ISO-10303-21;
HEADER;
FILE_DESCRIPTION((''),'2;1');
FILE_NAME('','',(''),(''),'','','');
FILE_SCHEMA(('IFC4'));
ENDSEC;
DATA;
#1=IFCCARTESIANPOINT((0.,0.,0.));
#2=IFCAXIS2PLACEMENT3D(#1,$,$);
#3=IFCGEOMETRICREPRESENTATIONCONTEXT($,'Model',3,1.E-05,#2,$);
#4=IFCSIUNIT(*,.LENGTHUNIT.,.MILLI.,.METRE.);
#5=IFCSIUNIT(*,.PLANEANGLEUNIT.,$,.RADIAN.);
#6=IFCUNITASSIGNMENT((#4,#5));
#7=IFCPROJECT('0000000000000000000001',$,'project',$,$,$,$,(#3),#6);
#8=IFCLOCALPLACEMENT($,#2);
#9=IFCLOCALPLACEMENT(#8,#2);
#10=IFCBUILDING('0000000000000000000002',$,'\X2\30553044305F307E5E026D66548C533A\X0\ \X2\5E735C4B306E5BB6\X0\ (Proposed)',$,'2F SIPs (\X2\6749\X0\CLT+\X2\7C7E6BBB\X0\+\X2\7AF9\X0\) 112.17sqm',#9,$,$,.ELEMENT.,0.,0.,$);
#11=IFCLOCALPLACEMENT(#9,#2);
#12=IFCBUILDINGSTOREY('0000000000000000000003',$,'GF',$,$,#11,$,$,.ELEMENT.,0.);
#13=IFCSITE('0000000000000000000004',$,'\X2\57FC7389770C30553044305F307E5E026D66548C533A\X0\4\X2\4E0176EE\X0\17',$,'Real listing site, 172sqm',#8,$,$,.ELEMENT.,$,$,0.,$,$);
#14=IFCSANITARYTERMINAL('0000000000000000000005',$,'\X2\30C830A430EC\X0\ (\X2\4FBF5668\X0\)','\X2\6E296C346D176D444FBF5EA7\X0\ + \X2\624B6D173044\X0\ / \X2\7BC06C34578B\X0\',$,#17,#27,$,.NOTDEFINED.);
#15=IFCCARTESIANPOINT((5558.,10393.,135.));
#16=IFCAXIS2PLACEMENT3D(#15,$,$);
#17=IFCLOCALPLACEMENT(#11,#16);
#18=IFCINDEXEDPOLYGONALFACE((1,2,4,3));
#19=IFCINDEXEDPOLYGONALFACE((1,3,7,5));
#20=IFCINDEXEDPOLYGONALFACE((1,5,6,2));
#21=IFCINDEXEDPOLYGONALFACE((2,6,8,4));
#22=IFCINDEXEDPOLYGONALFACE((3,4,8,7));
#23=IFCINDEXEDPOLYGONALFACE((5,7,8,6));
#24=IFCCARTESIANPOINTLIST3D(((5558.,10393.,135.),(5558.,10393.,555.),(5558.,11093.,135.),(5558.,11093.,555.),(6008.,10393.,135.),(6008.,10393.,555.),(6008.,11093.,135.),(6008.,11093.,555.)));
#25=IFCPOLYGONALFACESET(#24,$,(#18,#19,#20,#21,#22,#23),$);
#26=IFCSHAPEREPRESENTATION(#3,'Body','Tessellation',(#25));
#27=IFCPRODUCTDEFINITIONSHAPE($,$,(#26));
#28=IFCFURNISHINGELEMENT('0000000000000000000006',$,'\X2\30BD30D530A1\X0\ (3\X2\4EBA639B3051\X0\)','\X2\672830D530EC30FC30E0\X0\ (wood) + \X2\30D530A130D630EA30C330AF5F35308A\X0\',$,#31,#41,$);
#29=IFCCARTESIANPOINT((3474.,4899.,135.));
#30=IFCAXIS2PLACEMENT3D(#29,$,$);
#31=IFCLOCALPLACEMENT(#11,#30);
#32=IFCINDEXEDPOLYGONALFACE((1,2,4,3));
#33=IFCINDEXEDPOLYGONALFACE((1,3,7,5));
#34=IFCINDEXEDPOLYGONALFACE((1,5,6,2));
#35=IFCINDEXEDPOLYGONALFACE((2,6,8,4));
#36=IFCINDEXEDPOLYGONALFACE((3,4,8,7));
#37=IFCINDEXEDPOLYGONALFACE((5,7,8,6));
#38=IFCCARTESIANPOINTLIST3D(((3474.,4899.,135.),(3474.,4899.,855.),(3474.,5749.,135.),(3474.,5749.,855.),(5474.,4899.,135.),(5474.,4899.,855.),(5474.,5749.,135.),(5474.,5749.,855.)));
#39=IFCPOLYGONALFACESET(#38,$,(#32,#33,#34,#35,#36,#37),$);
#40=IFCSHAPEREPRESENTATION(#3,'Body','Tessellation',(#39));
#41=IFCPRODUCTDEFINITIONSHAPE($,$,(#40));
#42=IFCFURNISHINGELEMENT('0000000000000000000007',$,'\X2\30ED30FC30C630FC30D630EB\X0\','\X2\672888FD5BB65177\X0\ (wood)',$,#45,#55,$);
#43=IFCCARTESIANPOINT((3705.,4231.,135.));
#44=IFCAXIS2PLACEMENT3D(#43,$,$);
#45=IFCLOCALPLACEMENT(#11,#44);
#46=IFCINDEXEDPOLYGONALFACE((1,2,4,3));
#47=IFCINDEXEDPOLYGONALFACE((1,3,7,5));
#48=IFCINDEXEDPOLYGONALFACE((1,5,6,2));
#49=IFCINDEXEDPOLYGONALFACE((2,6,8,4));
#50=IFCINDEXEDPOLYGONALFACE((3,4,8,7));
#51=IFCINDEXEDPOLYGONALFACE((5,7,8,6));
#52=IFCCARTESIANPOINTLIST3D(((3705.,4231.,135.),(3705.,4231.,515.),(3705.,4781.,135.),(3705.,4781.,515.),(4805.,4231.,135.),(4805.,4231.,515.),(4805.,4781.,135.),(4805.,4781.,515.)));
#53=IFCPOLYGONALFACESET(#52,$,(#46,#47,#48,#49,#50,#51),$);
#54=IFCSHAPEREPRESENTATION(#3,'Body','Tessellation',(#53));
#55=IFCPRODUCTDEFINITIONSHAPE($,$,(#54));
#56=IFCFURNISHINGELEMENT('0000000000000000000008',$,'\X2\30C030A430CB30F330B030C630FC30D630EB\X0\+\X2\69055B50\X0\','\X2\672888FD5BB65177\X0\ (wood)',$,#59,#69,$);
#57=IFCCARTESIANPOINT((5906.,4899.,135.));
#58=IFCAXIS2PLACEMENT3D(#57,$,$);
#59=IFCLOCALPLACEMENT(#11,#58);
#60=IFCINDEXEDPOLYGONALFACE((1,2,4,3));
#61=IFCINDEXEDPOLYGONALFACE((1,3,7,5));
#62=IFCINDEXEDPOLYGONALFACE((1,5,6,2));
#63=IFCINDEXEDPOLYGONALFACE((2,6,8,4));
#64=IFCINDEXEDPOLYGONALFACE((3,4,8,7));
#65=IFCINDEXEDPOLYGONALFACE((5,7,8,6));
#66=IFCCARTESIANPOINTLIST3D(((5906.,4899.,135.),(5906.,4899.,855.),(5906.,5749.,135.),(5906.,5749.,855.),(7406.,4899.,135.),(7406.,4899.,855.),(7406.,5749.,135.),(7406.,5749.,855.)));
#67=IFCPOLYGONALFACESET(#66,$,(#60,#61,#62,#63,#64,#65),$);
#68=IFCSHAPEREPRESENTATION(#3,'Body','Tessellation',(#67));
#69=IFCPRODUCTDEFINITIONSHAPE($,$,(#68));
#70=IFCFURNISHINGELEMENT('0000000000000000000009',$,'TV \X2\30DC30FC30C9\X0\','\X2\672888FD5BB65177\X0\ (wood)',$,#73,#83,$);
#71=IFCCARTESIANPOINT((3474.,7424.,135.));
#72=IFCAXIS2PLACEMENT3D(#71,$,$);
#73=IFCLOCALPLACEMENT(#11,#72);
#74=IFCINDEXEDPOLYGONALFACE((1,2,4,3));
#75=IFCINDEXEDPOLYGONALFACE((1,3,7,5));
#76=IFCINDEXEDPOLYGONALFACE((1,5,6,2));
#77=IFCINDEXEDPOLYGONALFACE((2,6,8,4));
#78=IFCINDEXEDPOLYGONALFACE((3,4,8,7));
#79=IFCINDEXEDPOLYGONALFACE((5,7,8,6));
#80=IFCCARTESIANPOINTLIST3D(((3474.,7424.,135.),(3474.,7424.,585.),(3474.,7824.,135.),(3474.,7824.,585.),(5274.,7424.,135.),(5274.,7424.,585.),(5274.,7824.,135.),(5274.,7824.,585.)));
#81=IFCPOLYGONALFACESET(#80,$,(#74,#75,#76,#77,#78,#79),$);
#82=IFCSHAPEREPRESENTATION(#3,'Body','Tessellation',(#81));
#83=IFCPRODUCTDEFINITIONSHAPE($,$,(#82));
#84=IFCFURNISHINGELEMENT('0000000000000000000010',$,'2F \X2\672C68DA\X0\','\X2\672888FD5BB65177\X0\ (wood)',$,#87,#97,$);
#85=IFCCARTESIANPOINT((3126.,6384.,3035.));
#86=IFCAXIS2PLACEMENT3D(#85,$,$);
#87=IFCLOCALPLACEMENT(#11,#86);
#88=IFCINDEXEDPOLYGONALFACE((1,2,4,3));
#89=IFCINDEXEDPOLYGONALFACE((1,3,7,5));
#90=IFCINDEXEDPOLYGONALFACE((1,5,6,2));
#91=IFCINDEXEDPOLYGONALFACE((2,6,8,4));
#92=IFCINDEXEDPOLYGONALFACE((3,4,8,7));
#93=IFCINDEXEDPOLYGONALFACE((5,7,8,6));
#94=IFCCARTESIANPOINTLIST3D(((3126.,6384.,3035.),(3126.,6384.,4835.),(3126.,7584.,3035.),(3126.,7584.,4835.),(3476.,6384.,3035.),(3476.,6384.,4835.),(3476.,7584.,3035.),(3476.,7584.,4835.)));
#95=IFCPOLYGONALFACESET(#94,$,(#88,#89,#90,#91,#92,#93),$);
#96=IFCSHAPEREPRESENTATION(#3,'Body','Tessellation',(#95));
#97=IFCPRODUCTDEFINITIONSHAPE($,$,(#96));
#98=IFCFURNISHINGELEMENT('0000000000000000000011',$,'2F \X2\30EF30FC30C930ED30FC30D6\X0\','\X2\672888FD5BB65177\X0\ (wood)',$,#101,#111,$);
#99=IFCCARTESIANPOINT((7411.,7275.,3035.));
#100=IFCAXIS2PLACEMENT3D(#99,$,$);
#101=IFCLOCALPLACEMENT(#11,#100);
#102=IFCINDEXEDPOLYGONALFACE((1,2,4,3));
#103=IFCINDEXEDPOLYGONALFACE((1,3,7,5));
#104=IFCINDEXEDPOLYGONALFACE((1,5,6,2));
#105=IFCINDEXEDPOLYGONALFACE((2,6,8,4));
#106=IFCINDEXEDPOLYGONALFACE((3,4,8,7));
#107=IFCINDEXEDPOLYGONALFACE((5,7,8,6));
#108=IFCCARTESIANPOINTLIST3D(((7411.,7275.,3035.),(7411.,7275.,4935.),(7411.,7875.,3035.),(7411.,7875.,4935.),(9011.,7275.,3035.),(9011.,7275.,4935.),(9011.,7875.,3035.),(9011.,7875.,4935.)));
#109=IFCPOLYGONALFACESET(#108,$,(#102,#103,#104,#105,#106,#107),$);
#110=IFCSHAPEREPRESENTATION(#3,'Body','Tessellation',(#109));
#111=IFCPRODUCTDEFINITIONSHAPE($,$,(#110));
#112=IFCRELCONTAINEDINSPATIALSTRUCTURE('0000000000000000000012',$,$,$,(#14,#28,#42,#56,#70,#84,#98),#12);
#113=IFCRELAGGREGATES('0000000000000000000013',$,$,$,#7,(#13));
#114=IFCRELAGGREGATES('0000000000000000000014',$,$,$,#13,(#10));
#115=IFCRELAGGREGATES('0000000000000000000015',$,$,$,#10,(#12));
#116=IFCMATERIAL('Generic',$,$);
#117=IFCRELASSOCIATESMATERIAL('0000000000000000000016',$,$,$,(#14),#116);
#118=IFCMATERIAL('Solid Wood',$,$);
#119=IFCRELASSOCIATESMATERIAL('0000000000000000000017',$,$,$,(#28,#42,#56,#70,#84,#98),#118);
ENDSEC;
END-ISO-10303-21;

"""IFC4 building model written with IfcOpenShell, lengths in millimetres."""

from ifc_helpers import new_model, si_unit, frame, frame_2d, origin, place, context, project, spatial, rectangle, extrude, material, element, save


model = new_model("IFC4")

# Units and contexts
model_context = context("Model", 3, precision=1e-05, world=origin())
ifc_project = project(units=[si_unit("LENGTHUNIT", "METRE", prefix="MILLI"), si_unit("PLANEANGLEUNIT", "RADIAN")], contexts=[model_context])

# Site, building, storey
site_placement = place(None, origin())
site = spatial("IfcSite", under=ifc_project, at=site_placement, Name="埼玉県さいたま市浦和区4丁目17", ObjectType="Real listing site, 172sqm", CompositionType="ELEMENT", RefElevation=0.0)
building_placement = place(site_placement, origin())
building = spatial("IfcBuilding", under=site, at=building_placement, Name="さいたま市浦和区 平屋の家 (Proposed)", ObjectType="2F SIPs (杉CLT+籾殻+竹) 112.17sqm", CompositionType="ELEMENT", ElevationOfRefHeight=0.0, ElevationOfTerrain=0.0)
storey_placement = place(building_placement, origin())
storey = spatial("IfcBuildingStorey", under=building, at=storey_placement, Name="GF", CompositionType="ELEMENT", Elevation=0.0)

# Shared definitions
ifc_material_1 = material(Name="Generic")

# Shared definitions
ifc_material_2 = material(Name="Solid Wood")

# Sanitary terminal
sanitary_terminal_1_placement = place(storey_placement, frame((5558.0, 10393.0, 135.0)))
element("IfcSanitaryTerminal", 1, at=sanitary_terminal_1_placement, inside=storey, material=ifc_material_1, Name="トイレ (便器)", Description="温水洗浄便座 + 手洗い / 節水型", PredefinedType="NOTDEFINED", context=model_context, shape_type="SweptSolid", body=[
    extrude(rectangle(XDim=450.0, YDim=700.0, at=frame_2d((225.0, 350.0))), frame((5558.0, 10393.0, 135.0)), (0.0, 0.0, 1.0), 420.0),
])

# Furnishing elements
furnishing_1_placement = place(storey_placement, frame((3474.0, 4899.0, 135.0)))
element("IfcFurnishingElement", 2, at=furnishing_1_placement, inside=storey, material=ifc_material_2, Name="ソファ (3人掛け)", Description="木フレーム (wood) + ファブリック張り", context=model_context, shape_type="SweptSolid", body=[
    extrude(rectangle(XDim=2000.0, YDim=850.0, at=frame_2d((1000.0, 425.0))), frame((3474.0, 4899.0, 135.0)), (0.0, 0.0, 1.0), 720.0),
])
furnishing_2_placement = place(storey_placement, frame((3705.0, 4231.0, 135.0)))
element("IfcFurnishingElement", 3, at=furnishing_2_placement, inside=storey, material=ifc_material_2, Name="ローテーブル", Description="木製家具 (wood)", context=model_context, shape_type="SweptSolid", body=[
    extrude(rectangle(XDim=1100.0, YDim=550.0, at=frame_2d((550.0, 275.0))), frame((3705.0, 4231.0, 135.0)), (0.0, 0.0, 1.0), 380.0),
])
furnishing_3_placement = place(storey_placement, frame((5906.0, 4899.0, 135.0)))
element("IfcFurnishingElement", 4, at=furnishing_3_placement, inside=storey, material=ifc_material_2, Name="ダイニングテーブル+椅子", Description="木製家具 (wood)", context=model_context, shape_type="SweptSolid", body=[
    extrude(rectangle(XDim=1500.0, YDim=850.0, at=frame_2d((750.0, 425.0))), frame((5906.0, 4899.0, 135.0)), (0.0, 0.0, 1.0), 720.0),
])
furnishing_4_placement = place(storey_placement, frame((3474.0, 7424.0, 135.0)))
element("IfcFurnishingElement", 5, at=furnishing_4_placement, inside=storey, material=ifc_material_2, Name="TV ボード", Description="木製家具 (wood)", context=model_context, shape_type="SweptSolid", body=[
    extrude(rectangle(XDim=1800.0, YDim=400.0, at=frame_2d((900.0, 200.0))), frame((3474.0, 7424.0, 135.0)), (0.0, 0.0, 1.0), 450.0),
])
furnishing_5_placement = place(storey_placement, frame((3126.0, 6384.0, 3035.0)))
element("IfcFurnishingElement", 6, at=furnishing_5_placement, inside=storey, material=ifc_material_2, Name="2F 本棚", Description="木製家具 (wood)", context=model_context, shape_type="SweptSolid", body=[
    extrude(rectangle(XDim=350.0, YDim=1200.0, at=frame_2d((175.0, 600.0))), frame((3126.0, 6384.0, 3035.0)), (0.0, 0.0, 1.0), 1800.0),
])
furnishing_6_placement = place(storey_placement, frame((7411.0, 7275.0, 3035.0)))
element("IfcFurnishingElement", 7, at=furnishing_6_placement, inside=storey, material=ifc_material_2, Name="2F ワードローブ", Description="木製家具 (wood)", context=model_context, shape_type="SweptSolid", body=[
    extrude(rectangle(XDim=1600.0, YDim=600.0, at=frame_2d((800.0, 300.0))), frame((7411.0, 7275.0, 3035.0)), (0.0, 0.0, 1.0), 1900.0),
])

save(model, "model.ifc")
